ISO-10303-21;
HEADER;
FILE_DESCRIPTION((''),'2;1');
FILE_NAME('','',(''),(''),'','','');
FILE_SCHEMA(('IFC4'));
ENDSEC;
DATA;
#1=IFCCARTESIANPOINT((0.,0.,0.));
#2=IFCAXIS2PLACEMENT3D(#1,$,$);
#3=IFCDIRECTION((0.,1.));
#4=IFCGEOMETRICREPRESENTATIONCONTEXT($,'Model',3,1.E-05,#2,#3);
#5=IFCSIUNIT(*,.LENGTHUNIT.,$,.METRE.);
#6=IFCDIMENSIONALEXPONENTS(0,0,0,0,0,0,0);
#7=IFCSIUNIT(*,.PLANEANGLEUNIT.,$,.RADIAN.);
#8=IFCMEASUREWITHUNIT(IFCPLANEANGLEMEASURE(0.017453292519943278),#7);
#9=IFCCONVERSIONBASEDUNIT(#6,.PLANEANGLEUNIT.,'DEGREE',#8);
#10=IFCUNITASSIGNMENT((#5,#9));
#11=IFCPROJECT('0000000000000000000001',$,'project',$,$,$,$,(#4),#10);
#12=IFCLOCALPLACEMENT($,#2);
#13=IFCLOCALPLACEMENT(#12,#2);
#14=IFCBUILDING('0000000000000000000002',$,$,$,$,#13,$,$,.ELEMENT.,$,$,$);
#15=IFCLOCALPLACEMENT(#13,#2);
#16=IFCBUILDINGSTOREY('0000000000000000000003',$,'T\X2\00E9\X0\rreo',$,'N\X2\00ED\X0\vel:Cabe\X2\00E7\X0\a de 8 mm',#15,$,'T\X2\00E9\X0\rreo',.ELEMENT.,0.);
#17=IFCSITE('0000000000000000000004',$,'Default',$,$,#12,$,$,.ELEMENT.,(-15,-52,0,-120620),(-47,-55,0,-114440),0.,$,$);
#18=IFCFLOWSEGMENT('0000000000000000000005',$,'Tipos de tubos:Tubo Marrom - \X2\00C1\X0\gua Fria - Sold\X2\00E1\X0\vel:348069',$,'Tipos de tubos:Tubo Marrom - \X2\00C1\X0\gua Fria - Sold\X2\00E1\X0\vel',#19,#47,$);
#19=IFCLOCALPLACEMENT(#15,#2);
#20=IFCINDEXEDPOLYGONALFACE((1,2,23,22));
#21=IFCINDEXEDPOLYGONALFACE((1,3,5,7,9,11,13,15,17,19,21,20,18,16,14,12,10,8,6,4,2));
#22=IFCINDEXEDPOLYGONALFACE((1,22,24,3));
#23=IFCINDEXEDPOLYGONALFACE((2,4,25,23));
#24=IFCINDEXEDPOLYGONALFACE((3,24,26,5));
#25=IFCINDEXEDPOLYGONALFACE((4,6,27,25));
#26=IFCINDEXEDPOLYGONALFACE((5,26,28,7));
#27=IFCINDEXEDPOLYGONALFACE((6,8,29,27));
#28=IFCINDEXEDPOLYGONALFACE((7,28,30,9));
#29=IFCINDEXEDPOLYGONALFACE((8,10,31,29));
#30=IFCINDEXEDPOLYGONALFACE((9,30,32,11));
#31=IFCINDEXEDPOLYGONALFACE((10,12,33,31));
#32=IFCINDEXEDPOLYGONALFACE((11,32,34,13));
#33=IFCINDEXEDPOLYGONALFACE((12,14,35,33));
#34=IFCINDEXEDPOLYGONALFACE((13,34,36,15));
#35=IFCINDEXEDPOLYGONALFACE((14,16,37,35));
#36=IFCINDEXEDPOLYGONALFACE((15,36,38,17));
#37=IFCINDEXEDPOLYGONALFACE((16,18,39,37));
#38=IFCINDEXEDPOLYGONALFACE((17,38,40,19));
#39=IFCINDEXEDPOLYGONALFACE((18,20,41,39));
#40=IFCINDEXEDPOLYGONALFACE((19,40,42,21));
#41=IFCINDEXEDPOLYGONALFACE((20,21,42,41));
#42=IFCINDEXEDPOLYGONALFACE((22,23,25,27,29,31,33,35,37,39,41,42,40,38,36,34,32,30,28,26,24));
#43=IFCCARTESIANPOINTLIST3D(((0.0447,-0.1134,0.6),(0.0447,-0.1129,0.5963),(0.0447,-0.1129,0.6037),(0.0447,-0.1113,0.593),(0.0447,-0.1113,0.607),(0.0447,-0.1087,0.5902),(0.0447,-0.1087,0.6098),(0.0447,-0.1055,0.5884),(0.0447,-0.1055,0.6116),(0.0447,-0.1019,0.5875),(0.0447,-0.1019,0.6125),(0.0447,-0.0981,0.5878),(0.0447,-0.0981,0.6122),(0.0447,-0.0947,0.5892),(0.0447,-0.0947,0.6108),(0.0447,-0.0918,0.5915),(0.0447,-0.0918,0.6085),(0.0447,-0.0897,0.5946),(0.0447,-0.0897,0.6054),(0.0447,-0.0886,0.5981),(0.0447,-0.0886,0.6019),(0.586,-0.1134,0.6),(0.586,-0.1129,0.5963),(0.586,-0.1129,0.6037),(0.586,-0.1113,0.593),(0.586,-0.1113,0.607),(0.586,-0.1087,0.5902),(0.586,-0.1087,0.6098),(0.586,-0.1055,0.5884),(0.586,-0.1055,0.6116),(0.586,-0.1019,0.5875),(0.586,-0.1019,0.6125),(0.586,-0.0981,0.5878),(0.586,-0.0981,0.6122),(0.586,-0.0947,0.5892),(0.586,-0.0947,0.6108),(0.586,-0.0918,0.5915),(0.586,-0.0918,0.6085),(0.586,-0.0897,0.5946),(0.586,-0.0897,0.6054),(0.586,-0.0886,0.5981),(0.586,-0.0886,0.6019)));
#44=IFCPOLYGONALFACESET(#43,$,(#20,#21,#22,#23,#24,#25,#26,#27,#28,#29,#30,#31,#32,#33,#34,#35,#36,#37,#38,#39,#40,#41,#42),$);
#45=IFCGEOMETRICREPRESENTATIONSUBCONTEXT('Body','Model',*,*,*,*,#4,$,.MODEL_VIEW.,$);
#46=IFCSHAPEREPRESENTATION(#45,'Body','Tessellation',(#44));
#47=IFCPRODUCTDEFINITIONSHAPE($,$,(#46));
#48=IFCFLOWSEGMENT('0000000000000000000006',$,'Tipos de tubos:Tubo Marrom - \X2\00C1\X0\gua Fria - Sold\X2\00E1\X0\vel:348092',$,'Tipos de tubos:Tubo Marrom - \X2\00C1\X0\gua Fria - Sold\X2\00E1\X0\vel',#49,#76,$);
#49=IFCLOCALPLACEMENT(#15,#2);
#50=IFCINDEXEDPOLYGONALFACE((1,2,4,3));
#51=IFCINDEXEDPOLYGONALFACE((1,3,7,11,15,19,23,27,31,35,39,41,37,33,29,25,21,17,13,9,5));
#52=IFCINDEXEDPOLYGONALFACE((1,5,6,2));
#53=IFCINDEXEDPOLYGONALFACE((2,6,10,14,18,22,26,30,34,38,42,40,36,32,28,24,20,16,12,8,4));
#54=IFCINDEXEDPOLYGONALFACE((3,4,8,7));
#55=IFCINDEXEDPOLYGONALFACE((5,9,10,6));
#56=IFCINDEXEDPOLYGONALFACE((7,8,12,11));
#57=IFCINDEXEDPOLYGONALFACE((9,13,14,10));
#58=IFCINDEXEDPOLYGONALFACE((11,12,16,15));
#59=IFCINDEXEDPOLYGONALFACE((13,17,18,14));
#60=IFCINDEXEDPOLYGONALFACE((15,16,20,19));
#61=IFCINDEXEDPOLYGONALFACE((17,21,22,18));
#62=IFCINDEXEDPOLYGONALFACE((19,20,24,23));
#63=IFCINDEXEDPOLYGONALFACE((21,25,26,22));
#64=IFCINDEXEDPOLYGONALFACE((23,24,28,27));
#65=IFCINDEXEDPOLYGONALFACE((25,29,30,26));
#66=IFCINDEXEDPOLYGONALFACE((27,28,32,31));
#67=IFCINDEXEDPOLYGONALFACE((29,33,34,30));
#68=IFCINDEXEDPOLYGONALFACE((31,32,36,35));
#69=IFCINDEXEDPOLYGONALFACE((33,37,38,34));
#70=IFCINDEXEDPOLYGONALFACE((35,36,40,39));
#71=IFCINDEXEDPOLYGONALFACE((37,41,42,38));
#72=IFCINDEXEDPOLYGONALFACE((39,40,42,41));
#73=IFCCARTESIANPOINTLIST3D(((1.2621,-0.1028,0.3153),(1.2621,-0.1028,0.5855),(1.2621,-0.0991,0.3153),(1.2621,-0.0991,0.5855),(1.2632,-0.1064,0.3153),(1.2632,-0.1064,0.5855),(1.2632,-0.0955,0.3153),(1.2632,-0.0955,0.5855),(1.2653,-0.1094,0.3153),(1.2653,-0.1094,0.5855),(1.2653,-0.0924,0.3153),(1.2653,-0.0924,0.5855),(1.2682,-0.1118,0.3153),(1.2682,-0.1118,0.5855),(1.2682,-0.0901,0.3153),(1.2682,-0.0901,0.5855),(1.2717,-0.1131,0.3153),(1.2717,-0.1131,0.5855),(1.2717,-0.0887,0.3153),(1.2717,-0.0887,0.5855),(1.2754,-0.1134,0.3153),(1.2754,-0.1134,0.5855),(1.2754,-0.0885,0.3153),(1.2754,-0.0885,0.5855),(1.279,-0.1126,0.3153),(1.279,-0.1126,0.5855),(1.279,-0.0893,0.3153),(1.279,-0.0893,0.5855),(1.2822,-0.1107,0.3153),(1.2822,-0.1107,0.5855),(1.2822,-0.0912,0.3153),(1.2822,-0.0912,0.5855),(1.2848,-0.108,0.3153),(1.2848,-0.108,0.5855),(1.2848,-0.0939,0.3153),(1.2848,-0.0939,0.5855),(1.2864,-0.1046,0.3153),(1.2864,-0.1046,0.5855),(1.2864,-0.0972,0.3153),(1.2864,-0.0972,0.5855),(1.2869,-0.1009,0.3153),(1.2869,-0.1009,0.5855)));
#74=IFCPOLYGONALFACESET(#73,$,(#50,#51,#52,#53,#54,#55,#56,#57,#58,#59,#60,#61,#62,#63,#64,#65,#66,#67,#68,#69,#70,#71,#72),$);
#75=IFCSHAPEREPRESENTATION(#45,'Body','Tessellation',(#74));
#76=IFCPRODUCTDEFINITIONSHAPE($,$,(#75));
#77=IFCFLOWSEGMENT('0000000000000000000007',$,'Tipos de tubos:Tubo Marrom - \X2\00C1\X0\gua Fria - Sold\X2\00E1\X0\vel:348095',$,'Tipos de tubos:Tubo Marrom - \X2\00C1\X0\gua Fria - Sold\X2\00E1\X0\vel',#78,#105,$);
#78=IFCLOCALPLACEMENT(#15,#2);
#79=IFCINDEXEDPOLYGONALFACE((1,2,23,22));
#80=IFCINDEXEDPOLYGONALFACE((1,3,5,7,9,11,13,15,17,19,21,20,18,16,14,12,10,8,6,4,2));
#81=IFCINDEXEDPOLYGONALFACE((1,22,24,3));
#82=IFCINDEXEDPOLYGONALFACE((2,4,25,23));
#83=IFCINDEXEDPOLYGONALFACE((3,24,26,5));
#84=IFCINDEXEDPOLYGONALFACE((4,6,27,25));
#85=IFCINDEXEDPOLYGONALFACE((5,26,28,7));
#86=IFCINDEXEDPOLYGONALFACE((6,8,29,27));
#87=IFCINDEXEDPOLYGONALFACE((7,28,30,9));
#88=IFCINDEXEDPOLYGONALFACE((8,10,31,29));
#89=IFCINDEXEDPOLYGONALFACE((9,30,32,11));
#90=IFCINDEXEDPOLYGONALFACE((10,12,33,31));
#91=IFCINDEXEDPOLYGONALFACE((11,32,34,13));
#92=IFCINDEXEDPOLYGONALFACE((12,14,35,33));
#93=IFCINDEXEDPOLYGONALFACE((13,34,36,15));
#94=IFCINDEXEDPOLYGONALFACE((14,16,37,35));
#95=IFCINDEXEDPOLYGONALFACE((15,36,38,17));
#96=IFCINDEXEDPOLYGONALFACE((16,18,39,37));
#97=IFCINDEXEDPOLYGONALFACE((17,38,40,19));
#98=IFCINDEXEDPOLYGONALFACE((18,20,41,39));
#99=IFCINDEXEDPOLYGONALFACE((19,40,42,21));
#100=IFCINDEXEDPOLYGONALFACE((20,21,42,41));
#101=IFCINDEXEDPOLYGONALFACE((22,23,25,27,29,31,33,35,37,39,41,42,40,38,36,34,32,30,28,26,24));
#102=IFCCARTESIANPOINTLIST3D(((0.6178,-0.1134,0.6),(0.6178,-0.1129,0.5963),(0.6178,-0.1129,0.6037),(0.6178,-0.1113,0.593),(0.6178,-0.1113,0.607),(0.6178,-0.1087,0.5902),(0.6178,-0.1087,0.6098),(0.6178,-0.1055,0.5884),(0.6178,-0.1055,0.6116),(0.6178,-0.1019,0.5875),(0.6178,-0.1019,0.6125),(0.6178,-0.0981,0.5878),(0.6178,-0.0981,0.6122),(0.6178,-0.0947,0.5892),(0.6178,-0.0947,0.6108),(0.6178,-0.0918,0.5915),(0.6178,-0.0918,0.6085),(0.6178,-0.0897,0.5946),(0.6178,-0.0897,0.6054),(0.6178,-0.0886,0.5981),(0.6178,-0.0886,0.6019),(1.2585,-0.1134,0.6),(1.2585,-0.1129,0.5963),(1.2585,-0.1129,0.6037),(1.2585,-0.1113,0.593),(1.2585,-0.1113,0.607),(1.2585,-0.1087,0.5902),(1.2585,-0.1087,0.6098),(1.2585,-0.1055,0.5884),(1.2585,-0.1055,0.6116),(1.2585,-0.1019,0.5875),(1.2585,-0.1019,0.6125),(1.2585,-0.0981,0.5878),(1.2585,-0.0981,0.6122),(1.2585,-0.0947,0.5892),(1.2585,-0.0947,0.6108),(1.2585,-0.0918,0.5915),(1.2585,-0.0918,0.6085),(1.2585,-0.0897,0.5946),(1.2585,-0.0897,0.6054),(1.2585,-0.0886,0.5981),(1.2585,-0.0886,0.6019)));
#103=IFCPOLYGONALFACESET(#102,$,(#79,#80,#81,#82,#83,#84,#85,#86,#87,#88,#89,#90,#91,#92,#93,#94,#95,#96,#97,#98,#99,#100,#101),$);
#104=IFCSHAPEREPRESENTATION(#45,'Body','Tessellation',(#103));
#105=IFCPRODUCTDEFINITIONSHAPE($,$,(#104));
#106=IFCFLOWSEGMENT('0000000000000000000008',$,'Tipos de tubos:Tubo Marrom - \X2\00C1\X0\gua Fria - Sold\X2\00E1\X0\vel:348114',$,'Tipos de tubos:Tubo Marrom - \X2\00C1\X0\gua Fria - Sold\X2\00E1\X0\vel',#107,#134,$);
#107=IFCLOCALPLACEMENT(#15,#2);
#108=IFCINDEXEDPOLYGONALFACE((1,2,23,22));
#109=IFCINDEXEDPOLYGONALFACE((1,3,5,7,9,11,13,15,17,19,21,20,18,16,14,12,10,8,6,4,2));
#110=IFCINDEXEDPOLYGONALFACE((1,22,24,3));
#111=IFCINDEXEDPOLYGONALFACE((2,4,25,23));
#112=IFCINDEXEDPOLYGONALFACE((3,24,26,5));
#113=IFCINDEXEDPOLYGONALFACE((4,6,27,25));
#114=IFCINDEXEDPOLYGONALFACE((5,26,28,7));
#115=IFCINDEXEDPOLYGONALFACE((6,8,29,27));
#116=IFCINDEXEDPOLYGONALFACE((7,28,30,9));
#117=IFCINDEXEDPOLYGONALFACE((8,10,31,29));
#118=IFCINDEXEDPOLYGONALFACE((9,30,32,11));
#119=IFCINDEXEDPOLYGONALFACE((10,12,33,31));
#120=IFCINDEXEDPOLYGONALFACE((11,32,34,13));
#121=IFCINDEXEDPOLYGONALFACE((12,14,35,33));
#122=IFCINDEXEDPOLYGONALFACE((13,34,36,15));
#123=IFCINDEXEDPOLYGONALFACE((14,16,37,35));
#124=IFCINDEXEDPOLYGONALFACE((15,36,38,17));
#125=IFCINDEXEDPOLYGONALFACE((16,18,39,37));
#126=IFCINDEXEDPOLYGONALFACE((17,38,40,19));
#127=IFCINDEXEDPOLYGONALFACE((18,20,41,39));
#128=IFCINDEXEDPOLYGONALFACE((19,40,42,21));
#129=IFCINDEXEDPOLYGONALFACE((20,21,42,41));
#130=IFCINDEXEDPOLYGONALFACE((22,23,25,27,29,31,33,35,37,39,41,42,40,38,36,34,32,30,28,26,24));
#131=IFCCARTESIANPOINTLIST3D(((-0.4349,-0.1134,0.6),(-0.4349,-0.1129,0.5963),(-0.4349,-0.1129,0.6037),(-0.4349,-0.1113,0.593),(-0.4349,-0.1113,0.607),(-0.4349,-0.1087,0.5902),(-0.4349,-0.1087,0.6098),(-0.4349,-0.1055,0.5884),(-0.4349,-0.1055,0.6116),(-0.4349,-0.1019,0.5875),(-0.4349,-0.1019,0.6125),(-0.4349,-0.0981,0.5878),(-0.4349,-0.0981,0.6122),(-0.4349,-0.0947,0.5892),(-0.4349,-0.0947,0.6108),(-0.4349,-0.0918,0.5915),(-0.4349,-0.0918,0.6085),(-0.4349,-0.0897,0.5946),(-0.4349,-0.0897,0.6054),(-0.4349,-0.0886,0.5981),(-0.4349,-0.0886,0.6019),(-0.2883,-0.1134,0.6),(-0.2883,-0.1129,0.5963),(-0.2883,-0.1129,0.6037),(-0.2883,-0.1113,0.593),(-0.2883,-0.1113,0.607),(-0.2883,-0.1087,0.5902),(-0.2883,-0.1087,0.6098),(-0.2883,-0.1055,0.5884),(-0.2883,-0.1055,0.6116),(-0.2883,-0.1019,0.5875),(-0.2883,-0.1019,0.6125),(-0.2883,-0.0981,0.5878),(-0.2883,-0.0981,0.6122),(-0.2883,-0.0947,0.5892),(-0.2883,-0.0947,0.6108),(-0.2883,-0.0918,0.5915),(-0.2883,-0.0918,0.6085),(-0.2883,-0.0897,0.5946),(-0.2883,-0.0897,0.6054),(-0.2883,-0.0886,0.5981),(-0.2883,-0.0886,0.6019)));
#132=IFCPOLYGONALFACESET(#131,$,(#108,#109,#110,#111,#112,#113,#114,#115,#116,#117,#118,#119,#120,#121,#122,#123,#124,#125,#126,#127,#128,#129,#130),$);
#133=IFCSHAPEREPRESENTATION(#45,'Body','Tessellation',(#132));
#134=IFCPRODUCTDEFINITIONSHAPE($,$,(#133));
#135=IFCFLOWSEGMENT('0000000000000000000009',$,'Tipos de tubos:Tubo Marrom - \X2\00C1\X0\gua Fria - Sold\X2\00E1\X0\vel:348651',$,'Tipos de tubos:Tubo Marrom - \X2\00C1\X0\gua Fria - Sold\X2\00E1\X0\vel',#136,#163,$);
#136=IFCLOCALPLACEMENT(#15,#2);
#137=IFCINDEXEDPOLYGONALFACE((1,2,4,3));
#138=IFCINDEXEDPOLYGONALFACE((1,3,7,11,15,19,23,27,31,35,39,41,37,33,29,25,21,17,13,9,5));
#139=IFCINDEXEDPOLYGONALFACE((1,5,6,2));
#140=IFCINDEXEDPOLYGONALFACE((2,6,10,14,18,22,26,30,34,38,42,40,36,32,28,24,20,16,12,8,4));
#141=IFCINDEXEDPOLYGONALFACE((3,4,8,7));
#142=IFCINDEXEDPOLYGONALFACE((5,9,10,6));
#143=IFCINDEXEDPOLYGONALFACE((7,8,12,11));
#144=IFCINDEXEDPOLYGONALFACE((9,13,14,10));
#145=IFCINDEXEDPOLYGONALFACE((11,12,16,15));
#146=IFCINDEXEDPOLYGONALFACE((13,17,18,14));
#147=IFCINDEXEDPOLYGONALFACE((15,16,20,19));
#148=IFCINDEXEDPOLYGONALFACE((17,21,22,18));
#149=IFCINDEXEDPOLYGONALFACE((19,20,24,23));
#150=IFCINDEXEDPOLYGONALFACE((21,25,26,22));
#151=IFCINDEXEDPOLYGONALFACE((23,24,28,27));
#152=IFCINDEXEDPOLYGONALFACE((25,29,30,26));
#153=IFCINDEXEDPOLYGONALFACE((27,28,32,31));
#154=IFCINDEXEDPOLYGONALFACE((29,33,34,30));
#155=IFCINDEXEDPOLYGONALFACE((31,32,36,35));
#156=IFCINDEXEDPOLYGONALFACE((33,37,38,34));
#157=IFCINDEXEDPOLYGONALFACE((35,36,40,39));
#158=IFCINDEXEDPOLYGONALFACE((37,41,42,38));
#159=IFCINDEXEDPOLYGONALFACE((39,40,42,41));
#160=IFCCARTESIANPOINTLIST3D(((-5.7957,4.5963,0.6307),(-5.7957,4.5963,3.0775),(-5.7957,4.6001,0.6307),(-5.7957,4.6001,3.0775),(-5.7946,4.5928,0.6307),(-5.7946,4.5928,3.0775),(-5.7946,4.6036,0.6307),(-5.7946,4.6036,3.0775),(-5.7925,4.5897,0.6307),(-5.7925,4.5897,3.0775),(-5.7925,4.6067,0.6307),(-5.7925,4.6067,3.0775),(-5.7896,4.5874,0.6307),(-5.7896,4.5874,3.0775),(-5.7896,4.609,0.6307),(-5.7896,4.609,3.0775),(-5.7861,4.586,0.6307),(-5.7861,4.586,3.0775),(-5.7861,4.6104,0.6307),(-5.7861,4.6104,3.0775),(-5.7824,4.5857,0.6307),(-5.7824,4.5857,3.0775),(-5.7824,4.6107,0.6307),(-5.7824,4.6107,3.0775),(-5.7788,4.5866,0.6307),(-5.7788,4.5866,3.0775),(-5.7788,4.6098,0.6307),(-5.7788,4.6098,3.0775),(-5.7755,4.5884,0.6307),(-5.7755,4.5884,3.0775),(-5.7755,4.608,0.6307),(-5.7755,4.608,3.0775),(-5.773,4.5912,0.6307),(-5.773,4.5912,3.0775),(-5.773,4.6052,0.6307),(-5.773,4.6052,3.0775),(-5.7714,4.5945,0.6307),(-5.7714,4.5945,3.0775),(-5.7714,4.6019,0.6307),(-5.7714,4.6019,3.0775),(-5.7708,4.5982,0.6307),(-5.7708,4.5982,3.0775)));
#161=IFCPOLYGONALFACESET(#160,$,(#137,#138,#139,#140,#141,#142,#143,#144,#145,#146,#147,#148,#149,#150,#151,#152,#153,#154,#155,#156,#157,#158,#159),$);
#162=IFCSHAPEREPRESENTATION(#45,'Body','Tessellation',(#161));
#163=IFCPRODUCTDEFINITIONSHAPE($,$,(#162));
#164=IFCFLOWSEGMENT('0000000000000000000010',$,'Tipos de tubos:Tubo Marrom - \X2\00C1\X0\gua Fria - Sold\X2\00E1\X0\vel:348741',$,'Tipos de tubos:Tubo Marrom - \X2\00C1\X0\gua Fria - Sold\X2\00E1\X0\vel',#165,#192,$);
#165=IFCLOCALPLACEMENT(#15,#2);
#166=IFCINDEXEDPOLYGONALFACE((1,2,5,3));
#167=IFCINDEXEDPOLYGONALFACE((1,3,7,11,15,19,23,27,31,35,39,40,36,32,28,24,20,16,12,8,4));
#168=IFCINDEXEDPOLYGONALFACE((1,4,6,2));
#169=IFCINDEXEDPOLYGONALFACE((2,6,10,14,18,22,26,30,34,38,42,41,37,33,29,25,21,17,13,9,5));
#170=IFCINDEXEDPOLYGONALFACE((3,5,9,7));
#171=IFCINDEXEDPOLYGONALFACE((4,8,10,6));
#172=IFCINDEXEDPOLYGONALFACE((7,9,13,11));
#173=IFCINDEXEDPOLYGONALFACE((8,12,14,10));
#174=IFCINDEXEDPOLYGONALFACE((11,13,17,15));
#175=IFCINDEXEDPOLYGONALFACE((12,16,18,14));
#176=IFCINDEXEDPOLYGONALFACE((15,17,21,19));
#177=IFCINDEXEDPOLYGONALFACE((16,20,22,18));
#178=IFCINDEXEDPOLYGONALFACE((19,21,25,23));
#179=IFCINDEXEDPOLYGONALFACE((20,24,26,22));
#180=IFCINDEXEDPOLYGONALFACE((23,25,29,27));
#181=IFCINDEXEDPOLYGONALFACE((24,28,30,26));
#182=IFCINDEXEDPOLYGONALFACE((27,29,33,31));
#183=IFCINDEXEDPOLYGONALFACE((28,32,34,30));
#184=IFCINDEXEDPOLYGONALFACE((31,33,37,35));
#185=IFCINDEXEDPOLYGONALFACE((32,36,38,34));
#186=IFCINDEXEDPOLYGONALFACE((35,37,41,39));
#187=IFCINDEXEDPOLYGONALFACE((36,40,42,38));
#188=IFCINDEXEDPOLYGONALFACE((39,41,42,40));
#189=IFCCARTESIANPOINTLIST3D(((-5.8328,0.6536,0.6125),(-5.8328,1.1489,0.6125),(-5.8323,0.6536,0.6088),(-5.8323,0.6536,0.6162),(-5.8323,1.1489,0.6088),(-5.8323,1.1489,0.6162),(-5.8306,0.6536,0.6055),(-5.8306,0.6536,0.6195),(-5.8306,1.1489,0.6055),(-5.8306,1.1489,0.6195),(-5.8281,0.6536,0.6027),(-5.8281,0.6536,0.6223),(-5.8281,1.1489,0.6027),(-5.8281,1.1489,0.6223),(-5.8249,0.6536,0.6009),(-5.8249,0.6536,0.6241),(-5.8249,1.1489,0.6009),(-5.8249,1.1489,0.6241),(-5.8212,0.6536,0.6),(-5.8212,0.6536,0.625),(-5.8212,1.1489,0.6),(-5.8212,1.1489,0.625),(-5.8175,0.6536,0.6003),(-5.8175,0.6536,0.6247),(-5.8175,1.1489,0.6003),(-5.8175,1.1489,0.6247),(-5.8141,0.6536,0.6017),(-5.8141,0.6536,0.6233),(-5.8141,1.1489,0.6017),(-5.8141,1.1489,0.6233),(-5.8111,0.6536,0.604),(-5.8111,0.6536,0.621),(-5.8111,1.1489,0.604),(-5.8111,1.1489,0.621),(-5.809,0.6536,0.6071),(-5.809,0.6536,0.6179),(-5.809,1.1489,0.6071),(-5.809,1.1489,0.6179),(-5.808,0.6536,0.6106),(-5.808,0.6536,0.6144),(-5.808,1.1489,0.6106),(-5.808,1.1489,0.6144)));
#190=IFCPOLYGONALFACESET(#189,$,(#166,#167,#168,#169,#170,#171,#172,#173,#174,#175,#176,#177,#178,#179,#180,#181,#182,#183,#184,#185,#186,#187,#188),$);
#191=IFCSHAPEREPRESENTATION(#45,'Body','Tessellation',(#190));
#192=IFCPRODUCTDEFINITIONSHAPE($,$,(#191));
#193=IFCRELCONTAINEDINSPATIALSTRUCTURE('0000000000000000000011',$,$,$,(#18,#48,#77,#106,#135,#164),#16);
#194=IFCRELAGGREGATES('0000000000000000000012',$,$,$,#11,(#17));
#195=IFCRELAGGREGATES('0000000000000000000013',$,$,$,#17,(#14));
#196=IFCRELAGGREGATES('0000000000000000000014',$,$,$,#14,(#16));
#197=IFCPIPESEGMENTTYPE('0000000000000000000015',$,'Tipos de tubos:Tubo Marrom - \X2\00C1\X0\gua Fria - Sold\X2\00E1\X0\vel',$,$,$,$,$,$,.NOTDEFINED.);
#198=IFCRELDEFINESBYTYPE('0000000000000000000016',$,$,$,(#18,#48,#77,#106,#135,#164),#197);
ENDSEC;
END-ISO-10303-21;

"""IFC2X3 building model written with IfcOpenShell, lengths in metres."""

from ifc_helpers import new_model, entity, si_unit, converted_unit, direction, frame, frame_2d, origin, origin_2d_with_axis, place, context, subcontext, project, spatial, circle, extrude, type_object, element, save


model = new_model("IFC2X3")

# Units and contexts
model_context = context("Model", 3, precision=1e-05, world=origin(), true_north=direction((0.0, 1.0)))
body_context = subcontext(model_context, "Body", "Model", "MODEL_VIEW")
ifc_project = project(units=[si_unit("LENGTHUNIT", "METRE"), converted_unit("PLANEANGLEUNIT", "DEGREE", entity("IfcPlaneAngleMeasure", 0.017453292519943278), si_unit("PLANEANGLEUNIT", "RADIAN"), dimensions=[0, 0, 0, 0, 0, 0, 0])], contexts=[model_context])

# Site, building, storey
site_placement = place(None, origin())
site = spatial("IfcSite", under=ifc_project, at=site_placement, Name="Default", CompositionType="ELEMENT", RefLatitude=(-15, -52, 0, -120620), RefLongitude=(-47, -55, 0, -114440), RefElevation=0.0)
building_placement = place(site_placement, origin())
building = spatial("IfcBuilding", under=site, at=building_placement, CompositionType="ELEMENT")
storey_placement = place(building_placement, origin())
storey = spatial("IfcBuildingStorey", under=building, at=storey_placement, Name="Térreo", ObjectType="Nível:Cabeça de 8 mm", LongName="Térreo", CompositionType="ELEMENT", Elevation=0.0)

# Flow segments
pipe_segment_type = type_object("IfcPipeSegmentType", Name="Tipos de tubos:Tubo Marrom - Água Fria - Soldável", PredefinedType="NOTDEFINED")
flow_segment_1_placement = place(storey_placement, origin())
element("IfcFlowSegment", 1, at=flow_segment_1_placement, inside=storey, type_object=pipe_segment_type, Name="Tipos de tubos:Tubo Marrom - Água Fria - Soldável:348069", ObjectType="Tipos de tubos:Tubo Marrom - Água Fria - Soldável", context=body_context, shape_type="SweptSolid", body=[
    extrude(circle(Radius=0.0125, at=frame_2d((0.0, 0.0), x_axis=(1.0, 0.0))), frame((0.0447, -0.1009, 0.6), z_axis=(1.0, 0.0, 0.0), x_axis=(0.0, -1.0, 0.0)), (0.0, 0.0, 1.0), 0.5413),
])
flow_segment_2_placement = place(storey_placement, origin())
element("IfcFlowSegment", 2, at=flow_segment_2_placement, inside=storey, type_object=pipe_segment_type, Name="Tipos de tubos:Tubo Marrom - Água Fria - Soldável:348092", ObjectType="Tipos de tubos:Tubo Marrom - Água Fria - Soldável", context=body_context, shape_type="SweptSolid", body=[
    extrude(circle(Radius=0.0125, at=origin_2d_with_axis()), frame((1.2744, -0.1009, 0.3153)), (0.0, 0.0, 1.0), 0.2702),
])
flow_segment_3_placement = place(storey_placement, origin())
element("IfcFlowSegment", 3, at=flow_segment_3_placement, inside=storey, type_object=pipe_segment_type, Name="Tipos de tubos:Tubo Marrom - Água Fria - Soldável:348095", ObjectType="Tipos de tubos:Tubo Marrom - Água Fria - Soldável", context=body_context, shape_type="SweptSolid", body=[
    extrude(circle(Radius=0.0125, at=frame_2d((0.0, 0.0), x_axis=(1.0, 0.0))), frame((0.6178, -0.1009, 0.6), z_axis=(1.0, 0.0, 0.0), x_axis=(0.0, -1.0, 0.0)), (0.0, 0.0, 1.0), 0.6407),
])
flow_segment_4_placement = place(storey_placement, origin())
element("IfcFlowSegment", 4, at=flow_segment_4_placement, inside=storey, type_object=pipe_segment_type, Name="Tipos de tubos:Tubo Marrom - Água Fria - Soldável:348114", ObjectType="Tipos de tubos:Tubo Marrom - Água Fria - Soldável", context=body_context, shape_type="SweptSolid", body=[
    extrude(circle(Radius=0.0125, at=frame_2d((0.0, 0.0), x_axis=(1.0, 0.0))), frame((-0.4349, -0.1009, 0.6), z_axis=(1.0, 0.0, 0.0), x_axis=(0.0, -1.0, 0.0)), (0.0, 0.0, 1.0), 0.1466),
])
flow_segment_5_placement = place(storey_placement, origin())
element("IfcFlowSegment", 5, at=flow_segment_5_placement, inside=storey, type_object=pipe_segment_type, Name="Tipos de tubos:Tubo Marrom - Água Fria - Soldável:348651", ObjectType="Tipos de tubos:Tubo Marrom - Água Fria - Soldável", context=body_context, shape_type="SweptSolid", body=[
    extrude(circle(Radius=0.0125, at=frame_2d((0.0, 0.0), x_axis=(1.0, 0.0))), frame((-5.7833, 4.5982, 0.6307)), (0.0, 0.0, 1.0), 2.4468),
])
flow_segment_6_placement = place(storey_placement, origin())
element("IfcFlowSegment", 6, at=flow_segment_6_placement, inside=storey, type_object=pipe_segment_type, Name="Tipos de tubos:Tubo Marrom - Água Fria - Soldável:348741", ObjectType="Tipos de tubos:Tubo Marrom - Água Fria - Soldável", context=body_context, shape_type="SweptSolid", body=[
    extrude(circle(Radius=0.0125, at=frame_2d((0.0, 0.0), x_axis=(1.0, 0.0))), frame((-5.8203, 0.6536, 0.6125), z_axis=(0.0, 1.0, 0.0), x_axis=(-1.0, 0.0, 0.0)), (0.0, 0.0, 1.0), 0.4953),
])

save(model, "model.ifc")
